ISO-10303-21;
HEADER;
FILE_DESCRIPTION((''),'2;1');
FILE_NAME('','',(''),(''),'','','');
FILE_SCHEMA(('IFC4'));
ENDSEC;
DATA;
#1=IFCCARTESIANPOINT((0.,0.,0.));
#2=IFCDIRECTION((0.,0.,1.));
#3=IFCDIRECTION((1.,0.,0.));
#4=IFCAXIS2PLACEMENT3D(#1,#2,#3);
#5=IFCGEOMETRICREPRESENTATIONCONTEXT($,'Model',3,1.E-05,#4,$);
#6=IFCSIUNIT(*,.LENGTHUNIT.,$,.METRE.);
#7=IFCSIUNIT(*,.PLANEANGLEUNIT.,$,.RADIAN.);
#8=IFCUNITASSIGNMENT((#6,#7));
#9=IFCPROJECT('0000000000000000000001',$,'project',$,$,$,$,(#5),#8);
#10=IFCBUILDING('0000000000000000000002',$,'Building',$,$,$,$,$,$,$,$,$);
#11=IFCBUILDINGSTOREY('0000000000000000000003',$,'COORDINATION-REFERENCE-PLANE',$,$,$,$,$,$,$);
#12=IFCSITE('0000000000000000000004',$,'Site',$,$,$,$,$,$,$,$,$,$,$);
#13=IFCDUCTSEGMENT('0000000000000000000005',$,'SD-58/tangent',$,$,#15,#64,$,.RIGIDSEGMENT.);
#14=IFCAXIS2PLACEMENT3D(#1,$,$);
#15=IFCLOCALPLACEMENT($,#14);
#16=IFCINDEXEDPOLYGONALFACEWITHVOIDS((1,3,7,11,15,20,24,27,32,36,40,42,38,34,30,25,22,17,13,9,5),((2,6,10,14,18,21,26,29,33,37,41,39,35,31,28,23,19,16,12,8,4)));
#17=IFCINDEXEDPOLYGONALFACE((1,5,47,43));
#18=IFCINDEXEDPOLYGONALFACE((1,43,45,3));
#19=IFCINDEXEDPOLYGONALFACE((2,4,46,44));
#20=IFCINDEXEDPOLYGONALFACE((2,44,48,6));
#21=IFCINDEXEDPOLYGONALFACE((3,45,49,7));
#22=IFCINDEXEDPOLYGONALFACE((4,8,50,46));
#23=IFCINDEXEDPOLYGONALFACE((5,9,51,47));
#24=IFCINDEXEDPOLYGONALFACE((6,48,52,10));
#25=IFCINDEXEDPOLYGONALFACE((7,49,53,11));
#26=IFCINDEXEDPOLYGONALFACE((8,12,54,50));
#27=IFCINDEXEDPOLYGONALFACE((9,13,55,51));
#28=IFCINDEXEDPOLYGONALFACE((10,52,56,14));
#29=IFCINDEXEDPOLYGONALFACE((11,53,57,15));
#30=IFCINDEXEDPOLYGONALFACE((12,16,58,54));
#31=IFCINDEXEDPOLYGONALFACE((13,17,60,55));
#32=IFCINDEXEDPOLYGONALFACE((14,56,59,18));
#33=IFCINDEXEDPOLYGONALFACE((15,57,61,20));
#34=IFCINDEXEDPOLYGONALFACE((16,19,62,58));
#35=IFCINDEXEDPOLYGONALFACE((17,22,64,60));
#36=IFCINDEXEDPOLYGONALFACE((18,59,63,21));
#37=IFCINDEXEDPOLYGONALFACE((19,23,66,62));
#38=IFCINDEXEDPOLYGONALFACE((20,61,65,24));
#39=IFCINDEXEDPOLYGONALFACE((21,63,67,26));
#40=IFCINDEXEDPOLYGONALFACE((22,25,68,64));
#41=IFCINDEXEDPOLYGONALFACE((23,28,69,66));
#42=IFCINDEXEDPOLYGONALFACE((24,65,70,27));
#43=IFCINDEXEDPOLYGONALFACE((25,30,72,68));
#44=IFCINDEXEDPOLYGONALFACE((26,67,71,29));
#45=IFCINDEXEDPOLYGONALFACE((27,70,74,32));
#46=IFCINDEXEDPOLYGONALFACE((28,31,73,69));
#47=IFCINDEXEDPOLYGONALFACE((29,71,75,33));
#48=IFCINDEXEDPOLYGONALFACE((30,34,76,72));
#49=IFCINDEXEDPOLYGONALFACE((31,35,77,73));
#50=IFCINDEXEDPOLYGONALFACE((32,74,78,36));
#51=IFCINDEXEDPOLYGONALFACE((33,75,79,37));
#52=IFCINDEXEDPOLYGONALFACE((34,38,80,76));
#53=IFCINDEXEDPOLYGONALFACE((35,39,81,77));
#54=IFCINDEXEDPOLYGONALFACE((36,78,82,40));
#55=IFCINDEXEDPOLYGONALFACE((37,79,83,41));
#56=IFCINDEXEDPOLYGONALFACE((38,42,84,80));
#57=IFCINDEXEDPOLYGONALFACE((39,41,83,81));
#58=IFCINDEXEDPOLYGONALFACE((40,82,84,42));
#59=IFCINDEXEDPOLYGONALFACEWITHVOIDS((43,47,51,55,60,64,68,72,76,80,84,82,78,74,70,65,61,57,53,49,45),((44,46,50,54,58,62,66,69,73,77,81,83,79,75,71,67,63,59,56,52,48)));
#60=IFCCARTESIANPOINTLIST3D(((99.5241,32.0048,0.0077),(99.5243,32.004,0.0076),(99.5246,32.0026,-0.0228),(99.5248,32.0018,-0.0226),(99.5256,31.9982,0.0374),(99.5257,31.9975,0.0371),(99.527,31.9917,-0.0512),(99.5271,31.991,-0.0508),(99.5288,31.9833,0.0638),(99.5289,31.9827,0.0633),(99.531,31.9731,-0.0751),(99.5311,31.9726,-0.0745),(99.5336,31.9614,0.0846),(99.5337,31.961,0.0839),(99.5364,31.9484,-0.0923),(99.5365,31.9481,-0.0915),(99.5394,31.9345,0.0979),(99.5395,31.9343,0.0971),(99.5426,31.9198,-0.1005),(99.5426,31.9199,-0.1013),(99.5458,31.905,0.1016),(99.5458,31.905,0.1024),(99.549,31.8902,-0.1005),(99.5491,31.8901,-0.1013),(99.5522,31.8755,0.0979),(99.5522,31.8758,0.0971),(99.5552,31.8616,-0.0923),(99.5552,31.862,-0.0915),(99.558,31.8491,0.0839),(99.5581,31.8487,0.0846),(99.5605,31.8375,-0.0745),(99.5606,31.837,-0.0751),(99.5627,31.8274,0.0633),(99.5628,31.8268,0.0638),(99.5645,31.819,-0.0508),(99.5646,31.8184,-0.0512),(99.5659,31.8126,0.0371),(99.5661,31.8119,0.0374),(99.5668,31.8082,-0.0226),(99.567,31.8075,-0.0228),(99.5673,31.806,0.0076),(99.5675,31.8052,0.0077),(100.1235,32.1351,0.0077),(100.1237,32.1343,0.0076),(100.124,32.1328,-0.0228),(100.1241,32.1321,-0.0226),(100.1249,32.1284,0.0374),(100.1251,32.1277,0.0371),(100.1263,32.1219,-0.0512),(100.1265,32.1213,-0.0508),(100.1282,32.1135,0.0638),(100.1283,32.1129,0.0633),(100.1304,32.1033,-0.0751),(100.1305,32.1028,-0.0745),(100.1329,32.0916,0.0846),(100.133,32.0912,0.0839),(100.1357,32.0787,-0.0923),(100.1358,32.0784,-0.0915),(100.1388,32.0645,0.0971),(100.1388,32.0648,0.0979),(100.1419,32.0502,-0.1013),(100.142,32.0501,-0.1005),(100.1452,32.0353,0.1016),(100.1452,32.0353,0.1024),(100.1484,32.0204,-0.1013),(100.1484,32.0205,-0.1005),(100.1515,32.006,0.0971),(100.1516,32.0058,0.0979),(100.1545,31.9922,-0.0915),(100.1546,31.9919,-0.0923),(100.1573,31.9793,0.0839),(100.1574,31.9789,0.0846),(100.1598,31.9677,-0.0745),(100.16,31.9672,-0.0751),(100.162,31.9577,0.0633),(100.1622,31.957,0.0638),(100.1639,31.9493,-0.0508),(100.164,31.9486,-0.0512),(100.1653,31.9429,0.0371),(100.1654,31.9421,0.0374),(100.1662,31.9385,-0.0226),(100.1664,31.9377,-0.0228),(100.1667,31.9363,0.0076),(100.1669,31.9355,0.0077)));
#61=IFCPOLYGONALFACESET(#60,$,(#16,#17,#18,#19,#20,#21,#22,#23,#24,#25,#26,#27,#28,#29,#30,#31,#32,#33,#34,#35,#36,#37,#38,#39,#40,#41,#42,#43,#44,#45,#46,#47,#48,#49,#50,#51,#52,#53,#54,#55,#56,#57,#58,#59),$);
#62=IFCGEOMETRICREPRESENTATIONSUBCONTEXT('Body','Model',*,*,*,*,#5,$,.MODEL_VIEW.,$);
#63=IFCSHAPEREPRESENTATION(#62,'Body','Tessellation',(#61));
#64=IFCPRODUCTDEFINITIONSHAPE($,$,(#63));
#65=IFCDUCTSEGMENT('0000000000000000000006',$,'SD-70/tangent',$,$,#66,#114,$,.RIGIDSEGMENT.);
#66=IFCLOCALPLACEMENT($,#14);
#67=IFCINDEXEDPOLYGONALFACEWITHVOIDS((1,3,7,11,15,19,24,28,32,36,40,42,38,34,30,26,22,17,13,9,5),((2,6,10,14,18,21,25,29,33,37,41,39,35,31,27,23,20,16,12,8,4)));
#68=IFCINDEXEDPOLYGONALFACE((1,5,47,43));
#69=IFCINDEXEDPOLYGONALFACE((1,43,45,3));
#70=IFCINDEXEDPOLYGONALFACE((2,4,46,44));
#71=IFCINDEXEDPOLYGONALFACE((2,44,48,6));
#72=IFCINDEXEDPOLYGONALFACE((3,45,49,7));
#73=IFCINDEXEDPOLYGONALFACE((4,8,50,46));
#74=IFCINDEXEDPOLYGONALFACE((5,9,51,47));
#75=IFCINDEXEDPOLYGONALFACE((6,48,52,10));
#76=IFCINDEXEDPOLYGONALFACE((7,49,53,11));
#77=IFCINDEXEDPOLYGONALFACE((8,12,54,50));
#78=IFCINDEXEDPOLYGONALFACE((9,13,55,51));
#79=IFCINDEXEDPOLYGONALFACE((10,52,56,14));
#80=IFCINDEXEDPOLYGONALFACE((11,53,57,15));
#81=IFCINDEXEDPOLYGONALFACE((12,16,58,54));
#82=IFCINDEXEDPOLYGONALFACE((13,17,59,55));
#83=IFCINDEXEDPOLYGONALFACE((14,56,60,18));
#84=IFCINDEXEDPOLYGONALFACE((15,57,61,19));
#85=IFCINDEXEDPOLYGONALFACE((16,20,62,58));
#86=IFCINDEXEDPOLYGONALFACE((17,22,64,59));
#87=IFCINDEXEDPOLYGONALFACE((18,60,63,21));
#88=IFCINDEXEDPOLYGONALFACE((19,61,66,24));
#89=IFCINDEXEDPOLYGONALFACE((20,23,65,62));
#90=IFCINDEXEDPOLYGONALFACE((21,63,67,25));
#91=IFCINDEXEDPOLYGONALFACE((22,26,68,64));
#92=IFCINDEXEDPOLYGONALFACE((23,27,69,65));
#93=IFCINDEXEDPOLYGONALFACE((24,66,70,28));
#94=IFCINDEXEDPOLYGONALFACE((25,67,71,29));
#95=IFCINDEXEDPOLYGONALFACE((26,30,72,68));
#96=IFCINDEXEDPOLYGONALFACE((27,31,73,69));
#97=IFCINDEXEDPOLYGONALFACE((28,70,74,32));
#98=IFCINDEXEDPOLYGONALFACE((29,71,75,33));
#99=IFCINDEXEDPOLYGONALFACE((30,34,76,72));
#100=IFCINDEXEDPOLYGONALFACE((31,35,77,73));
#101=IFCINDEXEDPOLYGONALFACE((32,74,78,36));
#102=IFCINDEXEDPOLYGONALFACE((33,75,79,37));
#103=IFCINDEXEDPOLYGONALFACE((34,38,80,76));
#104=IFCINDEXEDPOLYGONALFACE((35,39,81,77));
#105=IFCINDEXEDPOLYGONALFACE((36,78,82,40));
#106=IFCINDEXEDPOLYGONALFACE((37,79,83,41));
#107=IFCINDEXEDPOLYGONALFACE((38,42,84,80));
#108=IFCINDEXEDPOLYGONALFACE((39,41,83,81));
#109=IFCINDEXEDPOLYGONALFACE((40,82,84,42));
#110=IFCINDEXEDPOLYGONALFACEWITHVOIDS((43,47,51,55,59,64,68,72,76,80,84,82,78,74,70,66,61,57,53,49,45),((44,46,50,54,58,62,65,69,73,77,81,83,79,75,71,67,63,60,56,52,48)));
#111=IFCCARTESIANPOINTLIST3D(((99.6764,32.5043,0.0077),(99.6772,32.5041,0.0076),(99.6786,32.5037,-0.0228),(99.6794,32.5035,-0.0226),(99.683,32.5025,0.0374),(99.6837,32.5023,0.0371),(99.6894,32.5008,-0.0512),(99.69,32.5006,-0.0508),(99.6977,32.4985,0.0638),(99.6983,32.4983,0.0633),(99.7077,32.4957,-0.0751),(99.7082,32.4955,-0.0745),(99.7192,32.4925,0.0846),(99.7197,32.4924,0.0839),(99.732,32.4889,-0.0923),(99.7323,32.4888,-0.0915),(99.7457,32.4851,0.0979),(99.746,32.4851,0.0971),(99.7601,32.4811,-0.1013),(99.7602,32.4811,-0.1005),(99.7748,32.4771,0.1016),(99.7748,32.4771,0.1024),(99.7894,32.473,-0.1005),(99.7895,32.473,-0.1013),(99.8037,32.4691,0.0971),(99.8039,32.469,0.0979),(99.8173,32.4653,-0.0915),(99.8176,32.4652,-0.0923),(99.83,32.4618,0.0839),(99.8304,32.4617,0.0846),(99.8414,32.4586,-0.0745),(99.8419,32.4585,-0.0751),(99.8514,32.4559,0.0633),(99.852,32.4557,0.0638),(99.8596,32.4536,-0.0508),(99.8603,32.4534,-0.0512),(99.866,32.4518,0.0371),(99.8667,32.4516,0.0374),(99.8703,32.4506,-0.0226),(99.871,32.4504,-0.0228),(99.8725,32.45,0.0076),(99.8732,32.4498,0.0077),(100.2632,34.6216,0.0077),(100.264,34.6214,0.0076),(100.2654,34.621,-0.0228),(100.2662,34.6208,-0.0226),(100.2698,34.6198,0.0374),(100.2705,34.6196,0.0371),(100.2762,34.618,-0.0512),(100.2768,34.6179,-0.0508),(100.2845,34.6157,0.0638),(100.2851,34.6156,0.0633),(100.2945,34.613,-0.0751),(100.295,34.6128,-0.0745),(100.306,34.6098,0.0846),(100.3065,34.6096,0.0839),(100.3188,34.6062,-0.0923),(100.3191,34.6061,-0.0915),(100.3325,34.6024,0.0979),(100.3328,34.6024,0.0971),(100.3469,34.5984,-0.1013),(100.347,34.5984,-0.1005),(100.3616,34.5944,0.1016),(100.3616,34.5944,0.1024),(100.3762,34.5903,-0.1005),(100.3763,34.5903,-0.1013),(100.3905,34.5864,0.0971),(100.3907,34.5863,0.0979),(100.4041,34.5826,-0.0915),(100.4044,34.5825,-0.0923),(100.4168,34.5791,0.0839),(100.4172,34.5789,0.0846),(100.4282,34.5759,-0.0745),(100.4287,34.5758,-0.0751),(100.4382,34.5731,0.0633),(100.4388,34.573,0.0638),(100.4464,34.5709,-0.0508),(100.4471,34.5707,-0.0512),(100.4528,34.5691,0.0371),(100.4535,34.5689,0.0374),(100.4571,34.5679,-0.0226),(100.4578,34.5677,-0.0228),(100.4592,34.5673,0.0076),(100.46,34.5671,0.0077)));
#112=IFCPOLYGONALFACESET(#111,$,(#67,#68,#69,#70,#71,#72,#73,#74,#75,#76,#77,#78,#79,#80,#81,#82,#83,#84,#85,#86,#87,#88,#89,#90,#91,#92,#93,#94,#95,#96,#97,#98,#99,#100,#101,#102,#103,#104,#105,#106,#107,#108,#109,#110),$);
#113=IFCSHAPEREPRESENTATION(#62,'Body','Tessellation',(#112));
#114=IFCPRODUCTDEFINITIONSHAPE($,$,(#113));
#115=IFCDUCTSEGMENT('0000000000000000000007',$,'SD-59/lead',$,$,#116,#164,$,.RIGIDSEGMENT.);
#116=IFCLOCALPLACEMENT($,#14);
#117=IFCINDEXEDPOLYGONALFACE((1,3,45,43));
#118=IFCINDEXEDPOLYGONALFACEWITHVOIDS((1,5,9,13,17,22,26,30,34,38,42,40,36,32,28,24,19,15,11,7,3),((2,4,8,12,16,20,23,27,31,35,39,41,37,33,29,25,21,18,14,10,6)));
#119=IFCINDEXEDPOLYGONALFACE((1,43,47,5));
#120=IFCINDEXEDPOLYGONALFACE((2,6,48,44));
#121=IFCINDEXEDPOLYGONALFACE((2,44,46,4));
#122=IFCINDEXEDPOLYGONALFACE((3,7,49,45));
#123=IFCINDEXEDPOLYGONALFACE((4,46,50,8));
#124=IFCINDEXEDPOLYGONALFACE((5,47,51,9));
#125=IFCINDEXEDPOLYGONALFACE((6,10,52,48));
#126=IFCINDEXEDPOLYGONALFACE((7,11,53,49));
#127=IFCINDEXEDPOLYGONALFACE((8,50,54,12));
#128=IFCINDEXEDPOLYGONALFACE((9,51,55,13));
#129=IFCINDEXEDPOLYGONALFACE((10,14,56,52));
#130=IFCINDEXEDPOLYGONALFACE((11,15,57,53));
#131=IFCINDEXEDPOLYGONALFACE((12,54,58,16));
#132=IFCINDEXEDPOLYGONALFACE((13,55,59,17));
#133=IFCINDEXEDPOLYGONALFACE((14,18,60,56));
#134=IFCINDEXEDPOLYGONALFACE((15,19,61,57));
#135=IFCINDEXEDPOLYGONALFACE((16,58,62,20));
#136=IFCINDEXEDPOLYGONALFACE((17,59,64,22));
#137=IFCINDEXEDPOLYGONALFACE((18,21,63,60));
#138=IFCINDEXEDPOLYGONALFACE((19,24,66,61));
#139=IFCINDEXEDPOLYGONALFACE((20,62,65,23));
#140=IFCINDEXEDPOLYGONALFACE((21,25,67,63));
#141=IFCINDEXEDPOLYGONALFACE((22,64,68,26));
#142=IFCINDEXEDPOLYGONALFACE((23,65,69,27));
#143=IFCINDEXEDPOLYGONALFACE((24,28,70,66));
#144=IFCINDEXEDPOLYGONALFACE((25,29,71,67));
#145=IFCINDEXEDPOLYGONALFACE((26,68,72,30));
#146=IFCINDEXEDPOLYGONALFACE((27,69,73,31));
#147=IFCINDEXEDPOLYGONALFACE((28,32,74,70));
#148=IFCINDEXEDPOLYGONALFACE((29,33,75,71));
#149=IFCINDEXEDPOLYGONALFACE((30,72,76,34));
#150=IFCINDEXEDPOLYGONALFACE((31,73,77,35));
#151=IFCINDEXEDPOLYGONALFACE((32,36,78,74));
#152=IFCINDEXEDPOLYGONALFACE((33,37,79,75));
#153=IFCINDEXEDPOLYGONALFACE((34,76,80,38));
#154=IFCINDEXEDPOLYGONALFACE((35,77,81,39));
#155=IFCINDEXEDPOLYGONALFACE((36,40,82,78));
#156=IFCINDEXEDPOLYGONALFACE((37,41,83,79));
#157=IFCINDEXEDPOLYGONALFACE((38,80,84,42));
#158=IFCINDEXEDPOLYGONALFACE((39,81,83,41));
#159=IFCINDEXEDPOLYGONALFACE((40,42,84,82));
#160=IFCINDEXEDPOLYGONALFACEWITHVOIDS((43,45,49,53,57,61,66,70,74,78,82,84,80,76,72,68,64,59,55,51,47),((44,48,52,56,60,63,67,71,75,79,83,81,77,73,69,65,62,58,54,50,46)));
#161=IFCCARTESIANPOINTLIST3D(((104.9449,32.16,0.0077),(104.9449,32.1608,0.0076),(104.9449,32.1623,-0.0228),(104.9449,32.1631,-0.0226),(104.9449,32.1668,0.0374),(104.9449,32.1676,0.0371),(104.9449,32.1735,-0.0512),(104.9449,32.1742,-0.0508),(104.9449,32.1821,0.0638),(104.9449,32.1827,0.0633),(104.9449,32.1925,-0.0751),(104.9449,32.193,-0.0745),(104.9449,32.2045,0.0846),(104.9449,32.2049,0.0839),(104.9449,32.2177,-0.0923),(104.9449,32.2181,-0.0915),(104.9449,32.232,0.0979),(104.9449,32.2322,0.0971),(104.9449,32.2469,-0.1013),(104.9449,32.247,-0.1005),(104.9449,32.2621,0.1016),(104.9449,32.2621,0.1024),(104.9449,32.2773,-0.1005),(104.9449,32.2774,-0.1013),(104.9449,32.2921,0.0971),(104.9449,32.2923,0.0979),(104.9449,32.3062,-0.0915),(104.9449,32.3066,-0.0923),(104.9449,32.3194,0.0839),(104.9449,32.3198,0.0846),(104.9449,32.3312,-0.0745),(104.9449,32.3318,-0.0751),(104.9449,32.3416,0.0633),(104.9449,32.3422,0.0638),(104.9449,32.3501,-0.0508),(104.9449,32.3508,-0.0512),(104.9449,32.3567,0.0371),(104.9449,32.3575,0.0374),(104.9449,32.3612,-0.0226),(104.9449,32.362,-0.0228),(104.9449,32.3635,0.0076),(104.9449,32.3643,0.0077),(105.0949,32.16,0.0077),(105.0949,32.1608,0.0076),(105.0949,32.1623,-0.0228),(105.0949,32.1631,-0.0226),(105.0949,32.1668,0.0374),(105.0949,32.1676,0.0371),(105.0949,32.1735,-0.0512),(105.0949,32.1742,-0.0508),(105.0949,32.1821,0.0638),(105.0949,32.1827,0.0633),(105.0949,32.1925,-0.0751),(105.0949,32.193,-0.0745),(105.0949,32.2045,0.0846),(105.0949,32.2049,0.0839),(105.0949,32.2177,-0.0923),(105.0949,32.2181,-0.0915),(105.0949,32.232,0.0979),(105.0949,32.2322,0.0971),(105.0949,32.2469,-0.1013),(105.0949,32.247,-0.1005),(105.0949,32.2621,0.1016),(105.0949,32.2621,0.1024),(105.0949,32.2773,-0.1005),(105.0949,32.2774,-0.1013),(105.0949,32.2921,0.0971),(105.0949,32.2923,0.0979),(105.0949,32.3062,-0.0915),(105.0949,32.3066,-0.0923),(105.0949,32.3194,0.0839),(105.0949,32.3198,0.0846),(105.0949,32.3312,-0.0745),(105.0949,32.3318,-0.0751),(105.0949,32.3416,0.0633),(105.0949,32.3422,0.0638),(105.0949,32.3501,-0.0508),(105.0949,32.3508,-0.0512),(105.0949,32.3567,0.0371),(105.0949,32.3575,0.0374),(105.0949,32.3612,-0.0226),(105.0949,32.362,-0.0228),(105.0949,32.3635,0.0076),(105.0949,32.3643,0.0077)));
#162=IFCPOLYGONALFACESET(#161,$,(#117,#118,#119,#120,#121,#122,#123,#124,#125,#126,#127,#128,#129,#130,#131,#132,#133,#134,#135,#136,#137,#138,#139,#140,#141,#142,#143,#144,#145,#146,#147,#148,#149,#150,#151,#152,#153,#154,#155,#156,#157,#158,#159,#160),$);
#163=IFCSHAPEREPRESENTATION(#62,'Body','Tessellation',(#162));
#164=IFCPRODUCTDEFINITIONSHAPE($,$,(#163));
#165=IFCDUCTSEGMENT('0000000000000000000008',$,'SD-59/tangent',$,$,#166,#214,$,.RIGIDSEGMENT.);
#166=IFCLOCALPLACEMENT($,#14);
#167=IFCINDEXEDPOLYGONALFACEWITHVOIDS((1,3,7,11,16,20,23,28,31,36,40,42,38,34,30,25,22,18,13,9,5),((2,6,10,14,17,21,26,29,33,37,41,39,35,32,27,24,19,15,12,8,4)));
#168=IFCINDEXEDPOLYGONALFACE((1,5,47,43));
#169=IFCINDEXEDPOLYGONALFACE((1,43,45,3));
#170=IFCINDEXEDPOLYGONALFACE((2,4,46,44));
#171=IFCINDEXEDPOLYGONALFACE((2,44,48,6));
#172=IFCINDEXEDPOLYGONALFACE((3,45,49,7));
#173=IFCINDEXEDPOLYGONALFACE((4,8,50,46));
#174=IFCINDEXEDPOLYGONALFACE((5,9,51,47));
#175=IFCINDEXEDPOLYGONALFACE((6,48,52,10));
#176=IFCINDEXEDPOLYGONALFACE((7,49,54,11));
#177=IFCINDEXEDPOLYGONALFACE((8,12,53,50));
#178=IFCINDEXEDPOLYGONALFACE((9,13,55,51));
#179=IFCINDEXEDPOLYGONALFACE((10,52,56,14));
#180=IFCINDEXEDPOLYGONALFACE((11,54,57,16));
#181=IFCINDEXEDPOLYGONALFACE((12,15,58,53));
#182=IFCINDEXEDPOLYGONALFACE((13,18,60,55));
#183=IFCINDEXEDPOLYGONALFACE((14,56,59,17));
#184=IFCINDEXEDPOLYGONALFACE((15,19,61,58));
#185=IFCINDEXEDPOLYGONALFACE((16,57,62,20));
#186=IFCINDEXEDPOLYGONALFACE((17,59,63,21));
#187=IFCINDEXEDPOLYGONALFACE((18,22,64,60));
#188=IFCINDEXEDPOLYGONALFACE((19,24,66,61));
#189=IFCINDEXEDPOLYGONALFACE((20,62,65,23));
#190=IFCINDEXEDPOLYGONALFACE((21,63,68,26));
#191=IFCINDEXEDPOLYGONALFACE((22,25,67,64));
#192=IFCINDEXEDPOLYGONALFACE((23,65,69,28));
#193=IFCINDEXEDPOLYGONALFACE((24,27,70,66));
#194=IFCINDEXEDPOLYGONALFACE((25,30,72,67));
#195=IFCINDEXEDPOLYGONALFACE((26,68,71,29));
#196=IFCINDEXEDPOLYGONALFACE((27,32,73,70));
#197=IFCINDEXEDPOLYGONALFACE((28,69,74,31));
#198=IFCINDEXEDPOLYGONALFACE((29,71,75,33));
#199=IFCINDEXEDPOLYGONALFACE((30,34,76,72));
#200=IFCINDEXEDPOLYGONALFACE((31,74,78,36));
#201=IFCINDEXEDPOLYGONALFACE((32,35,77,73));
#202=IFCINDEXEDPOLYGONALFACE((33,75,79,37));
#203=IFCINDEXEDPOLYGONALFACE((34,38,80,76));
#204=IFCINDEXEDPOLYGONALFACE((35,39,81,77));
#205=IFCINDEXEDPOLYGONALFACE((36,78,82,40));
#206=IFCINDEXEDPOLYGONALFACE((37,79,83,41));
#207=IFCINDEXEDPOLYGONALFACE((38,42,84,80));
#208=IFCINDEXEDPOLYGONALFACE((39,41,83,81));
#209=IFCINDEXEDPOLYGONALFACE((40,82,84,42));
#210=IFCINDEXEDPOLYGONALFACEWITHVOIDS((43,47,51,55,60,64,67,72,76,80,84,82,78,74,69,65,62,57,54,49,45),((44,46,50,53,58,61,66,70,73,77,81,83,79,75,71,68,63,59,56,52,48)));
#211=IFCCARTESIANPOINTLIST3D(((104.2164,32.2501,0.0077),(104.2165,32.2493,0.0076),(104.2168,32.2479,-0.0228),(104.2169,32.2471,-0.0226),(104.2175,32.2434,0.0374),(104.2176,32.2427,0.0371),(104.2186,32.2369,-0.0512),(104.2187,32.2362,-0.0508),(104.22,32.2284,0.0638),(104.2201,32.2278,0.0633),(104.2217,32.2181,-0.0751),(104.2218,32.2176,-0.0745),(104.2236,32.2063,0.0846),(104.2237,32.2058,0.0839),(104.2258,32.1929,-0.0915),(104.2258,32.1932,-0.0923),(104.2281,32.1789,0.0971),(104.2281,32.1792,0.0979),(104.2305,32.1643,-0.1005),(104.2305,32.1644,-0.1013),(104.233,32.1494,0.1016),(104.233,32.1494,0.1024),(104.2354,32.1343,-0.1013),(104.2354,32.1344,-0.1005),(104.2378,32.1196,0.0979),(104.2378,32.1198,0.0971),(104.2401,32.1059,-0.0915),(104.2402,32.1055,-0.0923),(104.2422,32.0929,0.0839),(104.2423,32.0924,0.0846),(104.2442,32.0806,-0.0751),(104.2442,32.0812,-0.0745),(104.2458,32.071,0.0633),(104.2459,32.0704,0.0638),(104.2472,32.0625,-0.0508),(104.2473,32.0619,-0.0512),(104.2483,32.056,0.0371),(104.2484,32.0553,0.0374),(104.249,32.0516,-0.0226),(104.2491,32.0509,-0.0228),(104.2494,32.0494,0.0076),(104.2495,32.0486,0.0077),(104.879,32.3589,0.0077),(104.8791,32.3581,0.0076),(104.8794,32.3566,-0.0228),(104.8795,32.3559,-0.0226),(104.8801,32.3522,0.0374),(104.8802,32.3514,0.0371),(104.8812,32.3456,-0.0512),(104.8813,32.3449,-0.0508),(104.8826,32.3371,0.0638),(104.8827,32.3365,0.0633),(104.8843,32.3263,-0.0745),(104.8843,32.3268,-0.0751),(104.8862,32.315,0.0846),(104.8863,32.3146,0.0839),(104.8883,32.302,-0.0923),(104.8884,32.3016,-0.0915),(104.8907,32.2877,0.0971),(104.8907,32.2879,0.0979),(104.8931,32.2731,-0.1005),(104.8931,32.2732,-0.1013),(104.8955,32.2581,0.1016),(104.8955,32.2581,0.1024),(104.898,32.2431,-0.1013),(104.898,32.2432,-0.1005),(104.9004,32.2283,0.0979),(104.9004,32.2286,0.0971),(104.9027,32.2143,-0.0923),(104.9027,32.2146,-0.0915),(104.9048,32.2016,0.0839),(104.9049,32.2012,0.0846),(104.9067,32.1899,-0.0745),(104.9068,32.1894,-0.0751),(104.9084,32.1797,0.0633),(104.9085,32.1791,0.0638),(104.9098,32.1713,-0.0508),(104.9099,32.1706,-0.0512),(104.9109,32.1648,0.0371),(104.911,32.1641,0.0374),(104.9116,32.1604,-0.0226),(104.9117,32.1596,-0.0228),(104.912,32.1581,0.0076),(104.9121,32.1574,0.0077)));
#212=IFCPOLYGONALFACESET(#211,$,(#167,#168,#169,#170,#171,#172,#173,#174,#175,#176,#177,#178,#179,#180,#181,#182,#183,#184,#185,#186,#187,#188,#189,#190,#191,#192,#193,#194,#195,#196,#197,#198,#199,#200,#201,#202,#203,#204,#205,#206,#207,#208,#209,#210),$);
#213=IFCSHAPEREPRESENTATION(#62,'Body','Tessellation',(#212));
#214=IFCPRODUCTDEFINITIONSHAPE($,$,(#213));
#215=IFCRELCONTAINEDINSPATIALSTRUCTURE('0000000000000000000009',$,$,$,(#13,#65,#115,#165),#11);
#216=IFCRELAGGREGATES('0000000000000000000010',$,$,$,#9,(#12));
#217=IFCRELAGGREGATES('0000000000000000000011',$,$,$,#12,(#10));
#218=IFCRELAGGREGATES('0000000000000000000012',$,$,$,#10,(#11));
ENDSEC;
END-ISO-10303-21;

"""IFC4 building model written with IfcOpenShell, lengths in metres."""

from ifc_helpers import new_model, si_unit, frame, origin_with_axes, place, context, subcontext, project, spatial, hollow_circle, extrude, element, save


model = new_model("IFC4")

# Units and contexts
model_context = context("Model", 3, precision=1e-05, world=origin_with_axes())
body_context_1 = subcontext(model_context, "Body", "Model", "MODEL_VIEW")
ifc_project = project(units=[si_unit("LENGTHUNIT", "METRE"), si_unit("PLANEANGLEUNIT", "RADIAN")], contexts=[model_context])

# Site, building, storey
site = spatial("IfcSite", under=ifc_project, Name="Site")
building = spatial("IfcBuilding", under=site, Name="Building")
storey = spatial("IfcBuildingStorey", under=building, Name="COORDINATION-REFERENCE-PLANE")

# Duct segment
duct_segment_1_placement = place(None, frame((99.5458, 31.905, 0.0), z_axis=(0.977193, 0.212353, 0.0), x_axis=(0.0, 0.0, 1.0)))
element("IfcDuctSegment", 1, at=duct_segment_1_placement, inside=storey, Name="SD-58/tangent", PredefinedType="RIGIDSEGMENT", context=body_context_1, shape_type="SweptSolid", body=[
    extrude(hollow_circle(Radius=0.1024, WallThickness=0.0008), origin_with_axes(), (0.0, 0.0, 1.0), 0.6133),
])

# Duct segment
duct_segment_2_placement = place(None, frame((99.7748, 32.4771, 0.0), z_axis=(0.267077, 0.963675, 0.0), x_axis=(0.0, 0.0, 1.0)))
element("IfcDuctSegment", 2, at=duct_segment_2_placement, inside=storey, Name="SD-70/tangent", PredefinedType="RIGIDSEGMENT", context=body_context_1, shape_type="SweptSolid", body=[
    extrude(hollow_circle(Radius=0.1024, WallThickness=0.0008), origin_with_axes(), (0.0, 0.0, 1.0), 2.1971),
])

# Duct segment
duct_segment_3_placement = place(None, frame((105.0949, 32.2621, 0.0), z_axis=(-1.0, 0.0, 0.0), x_axis=(0.0, 0.0, 1.0)))
element("IfcDuctSegment", 3, at=duct_segment_3_placement, inside=storey, Name="SD-59/lead", PredefinedType="RIGIDSEGMENT", context=body_context_1, shape_type="SweptSolid", body=[
    extrude(hollow_circle(Radius=0.1024, WallThickness=0.0008), origin_with_axes(), (0.0, 0.0, 1.0), 0.15),
])

# Duct segment
duct_segment_4_placement = place(None, frame((104.8955, 32.2581, 0.0), z_axis=(-0.986797, -0.161964, 0.0), x_axis=(0.0, 0.0, 1.0)))
element("IfcDuctSegment", 4, at=duct_segment_4_placement, inside=storey, Name="SD-59/tangent", PredefinedType="RIGIDSEGMENT", context=body_context_1, shape_type="SweptSolid", body=[
    extrude(hollow_circle(Radius=0.1024, WallThickness=0.0008), origin_with_axes(), (0.0, 0.0, 1.0), 0.6714),
])

save(model, "model.ifc")
